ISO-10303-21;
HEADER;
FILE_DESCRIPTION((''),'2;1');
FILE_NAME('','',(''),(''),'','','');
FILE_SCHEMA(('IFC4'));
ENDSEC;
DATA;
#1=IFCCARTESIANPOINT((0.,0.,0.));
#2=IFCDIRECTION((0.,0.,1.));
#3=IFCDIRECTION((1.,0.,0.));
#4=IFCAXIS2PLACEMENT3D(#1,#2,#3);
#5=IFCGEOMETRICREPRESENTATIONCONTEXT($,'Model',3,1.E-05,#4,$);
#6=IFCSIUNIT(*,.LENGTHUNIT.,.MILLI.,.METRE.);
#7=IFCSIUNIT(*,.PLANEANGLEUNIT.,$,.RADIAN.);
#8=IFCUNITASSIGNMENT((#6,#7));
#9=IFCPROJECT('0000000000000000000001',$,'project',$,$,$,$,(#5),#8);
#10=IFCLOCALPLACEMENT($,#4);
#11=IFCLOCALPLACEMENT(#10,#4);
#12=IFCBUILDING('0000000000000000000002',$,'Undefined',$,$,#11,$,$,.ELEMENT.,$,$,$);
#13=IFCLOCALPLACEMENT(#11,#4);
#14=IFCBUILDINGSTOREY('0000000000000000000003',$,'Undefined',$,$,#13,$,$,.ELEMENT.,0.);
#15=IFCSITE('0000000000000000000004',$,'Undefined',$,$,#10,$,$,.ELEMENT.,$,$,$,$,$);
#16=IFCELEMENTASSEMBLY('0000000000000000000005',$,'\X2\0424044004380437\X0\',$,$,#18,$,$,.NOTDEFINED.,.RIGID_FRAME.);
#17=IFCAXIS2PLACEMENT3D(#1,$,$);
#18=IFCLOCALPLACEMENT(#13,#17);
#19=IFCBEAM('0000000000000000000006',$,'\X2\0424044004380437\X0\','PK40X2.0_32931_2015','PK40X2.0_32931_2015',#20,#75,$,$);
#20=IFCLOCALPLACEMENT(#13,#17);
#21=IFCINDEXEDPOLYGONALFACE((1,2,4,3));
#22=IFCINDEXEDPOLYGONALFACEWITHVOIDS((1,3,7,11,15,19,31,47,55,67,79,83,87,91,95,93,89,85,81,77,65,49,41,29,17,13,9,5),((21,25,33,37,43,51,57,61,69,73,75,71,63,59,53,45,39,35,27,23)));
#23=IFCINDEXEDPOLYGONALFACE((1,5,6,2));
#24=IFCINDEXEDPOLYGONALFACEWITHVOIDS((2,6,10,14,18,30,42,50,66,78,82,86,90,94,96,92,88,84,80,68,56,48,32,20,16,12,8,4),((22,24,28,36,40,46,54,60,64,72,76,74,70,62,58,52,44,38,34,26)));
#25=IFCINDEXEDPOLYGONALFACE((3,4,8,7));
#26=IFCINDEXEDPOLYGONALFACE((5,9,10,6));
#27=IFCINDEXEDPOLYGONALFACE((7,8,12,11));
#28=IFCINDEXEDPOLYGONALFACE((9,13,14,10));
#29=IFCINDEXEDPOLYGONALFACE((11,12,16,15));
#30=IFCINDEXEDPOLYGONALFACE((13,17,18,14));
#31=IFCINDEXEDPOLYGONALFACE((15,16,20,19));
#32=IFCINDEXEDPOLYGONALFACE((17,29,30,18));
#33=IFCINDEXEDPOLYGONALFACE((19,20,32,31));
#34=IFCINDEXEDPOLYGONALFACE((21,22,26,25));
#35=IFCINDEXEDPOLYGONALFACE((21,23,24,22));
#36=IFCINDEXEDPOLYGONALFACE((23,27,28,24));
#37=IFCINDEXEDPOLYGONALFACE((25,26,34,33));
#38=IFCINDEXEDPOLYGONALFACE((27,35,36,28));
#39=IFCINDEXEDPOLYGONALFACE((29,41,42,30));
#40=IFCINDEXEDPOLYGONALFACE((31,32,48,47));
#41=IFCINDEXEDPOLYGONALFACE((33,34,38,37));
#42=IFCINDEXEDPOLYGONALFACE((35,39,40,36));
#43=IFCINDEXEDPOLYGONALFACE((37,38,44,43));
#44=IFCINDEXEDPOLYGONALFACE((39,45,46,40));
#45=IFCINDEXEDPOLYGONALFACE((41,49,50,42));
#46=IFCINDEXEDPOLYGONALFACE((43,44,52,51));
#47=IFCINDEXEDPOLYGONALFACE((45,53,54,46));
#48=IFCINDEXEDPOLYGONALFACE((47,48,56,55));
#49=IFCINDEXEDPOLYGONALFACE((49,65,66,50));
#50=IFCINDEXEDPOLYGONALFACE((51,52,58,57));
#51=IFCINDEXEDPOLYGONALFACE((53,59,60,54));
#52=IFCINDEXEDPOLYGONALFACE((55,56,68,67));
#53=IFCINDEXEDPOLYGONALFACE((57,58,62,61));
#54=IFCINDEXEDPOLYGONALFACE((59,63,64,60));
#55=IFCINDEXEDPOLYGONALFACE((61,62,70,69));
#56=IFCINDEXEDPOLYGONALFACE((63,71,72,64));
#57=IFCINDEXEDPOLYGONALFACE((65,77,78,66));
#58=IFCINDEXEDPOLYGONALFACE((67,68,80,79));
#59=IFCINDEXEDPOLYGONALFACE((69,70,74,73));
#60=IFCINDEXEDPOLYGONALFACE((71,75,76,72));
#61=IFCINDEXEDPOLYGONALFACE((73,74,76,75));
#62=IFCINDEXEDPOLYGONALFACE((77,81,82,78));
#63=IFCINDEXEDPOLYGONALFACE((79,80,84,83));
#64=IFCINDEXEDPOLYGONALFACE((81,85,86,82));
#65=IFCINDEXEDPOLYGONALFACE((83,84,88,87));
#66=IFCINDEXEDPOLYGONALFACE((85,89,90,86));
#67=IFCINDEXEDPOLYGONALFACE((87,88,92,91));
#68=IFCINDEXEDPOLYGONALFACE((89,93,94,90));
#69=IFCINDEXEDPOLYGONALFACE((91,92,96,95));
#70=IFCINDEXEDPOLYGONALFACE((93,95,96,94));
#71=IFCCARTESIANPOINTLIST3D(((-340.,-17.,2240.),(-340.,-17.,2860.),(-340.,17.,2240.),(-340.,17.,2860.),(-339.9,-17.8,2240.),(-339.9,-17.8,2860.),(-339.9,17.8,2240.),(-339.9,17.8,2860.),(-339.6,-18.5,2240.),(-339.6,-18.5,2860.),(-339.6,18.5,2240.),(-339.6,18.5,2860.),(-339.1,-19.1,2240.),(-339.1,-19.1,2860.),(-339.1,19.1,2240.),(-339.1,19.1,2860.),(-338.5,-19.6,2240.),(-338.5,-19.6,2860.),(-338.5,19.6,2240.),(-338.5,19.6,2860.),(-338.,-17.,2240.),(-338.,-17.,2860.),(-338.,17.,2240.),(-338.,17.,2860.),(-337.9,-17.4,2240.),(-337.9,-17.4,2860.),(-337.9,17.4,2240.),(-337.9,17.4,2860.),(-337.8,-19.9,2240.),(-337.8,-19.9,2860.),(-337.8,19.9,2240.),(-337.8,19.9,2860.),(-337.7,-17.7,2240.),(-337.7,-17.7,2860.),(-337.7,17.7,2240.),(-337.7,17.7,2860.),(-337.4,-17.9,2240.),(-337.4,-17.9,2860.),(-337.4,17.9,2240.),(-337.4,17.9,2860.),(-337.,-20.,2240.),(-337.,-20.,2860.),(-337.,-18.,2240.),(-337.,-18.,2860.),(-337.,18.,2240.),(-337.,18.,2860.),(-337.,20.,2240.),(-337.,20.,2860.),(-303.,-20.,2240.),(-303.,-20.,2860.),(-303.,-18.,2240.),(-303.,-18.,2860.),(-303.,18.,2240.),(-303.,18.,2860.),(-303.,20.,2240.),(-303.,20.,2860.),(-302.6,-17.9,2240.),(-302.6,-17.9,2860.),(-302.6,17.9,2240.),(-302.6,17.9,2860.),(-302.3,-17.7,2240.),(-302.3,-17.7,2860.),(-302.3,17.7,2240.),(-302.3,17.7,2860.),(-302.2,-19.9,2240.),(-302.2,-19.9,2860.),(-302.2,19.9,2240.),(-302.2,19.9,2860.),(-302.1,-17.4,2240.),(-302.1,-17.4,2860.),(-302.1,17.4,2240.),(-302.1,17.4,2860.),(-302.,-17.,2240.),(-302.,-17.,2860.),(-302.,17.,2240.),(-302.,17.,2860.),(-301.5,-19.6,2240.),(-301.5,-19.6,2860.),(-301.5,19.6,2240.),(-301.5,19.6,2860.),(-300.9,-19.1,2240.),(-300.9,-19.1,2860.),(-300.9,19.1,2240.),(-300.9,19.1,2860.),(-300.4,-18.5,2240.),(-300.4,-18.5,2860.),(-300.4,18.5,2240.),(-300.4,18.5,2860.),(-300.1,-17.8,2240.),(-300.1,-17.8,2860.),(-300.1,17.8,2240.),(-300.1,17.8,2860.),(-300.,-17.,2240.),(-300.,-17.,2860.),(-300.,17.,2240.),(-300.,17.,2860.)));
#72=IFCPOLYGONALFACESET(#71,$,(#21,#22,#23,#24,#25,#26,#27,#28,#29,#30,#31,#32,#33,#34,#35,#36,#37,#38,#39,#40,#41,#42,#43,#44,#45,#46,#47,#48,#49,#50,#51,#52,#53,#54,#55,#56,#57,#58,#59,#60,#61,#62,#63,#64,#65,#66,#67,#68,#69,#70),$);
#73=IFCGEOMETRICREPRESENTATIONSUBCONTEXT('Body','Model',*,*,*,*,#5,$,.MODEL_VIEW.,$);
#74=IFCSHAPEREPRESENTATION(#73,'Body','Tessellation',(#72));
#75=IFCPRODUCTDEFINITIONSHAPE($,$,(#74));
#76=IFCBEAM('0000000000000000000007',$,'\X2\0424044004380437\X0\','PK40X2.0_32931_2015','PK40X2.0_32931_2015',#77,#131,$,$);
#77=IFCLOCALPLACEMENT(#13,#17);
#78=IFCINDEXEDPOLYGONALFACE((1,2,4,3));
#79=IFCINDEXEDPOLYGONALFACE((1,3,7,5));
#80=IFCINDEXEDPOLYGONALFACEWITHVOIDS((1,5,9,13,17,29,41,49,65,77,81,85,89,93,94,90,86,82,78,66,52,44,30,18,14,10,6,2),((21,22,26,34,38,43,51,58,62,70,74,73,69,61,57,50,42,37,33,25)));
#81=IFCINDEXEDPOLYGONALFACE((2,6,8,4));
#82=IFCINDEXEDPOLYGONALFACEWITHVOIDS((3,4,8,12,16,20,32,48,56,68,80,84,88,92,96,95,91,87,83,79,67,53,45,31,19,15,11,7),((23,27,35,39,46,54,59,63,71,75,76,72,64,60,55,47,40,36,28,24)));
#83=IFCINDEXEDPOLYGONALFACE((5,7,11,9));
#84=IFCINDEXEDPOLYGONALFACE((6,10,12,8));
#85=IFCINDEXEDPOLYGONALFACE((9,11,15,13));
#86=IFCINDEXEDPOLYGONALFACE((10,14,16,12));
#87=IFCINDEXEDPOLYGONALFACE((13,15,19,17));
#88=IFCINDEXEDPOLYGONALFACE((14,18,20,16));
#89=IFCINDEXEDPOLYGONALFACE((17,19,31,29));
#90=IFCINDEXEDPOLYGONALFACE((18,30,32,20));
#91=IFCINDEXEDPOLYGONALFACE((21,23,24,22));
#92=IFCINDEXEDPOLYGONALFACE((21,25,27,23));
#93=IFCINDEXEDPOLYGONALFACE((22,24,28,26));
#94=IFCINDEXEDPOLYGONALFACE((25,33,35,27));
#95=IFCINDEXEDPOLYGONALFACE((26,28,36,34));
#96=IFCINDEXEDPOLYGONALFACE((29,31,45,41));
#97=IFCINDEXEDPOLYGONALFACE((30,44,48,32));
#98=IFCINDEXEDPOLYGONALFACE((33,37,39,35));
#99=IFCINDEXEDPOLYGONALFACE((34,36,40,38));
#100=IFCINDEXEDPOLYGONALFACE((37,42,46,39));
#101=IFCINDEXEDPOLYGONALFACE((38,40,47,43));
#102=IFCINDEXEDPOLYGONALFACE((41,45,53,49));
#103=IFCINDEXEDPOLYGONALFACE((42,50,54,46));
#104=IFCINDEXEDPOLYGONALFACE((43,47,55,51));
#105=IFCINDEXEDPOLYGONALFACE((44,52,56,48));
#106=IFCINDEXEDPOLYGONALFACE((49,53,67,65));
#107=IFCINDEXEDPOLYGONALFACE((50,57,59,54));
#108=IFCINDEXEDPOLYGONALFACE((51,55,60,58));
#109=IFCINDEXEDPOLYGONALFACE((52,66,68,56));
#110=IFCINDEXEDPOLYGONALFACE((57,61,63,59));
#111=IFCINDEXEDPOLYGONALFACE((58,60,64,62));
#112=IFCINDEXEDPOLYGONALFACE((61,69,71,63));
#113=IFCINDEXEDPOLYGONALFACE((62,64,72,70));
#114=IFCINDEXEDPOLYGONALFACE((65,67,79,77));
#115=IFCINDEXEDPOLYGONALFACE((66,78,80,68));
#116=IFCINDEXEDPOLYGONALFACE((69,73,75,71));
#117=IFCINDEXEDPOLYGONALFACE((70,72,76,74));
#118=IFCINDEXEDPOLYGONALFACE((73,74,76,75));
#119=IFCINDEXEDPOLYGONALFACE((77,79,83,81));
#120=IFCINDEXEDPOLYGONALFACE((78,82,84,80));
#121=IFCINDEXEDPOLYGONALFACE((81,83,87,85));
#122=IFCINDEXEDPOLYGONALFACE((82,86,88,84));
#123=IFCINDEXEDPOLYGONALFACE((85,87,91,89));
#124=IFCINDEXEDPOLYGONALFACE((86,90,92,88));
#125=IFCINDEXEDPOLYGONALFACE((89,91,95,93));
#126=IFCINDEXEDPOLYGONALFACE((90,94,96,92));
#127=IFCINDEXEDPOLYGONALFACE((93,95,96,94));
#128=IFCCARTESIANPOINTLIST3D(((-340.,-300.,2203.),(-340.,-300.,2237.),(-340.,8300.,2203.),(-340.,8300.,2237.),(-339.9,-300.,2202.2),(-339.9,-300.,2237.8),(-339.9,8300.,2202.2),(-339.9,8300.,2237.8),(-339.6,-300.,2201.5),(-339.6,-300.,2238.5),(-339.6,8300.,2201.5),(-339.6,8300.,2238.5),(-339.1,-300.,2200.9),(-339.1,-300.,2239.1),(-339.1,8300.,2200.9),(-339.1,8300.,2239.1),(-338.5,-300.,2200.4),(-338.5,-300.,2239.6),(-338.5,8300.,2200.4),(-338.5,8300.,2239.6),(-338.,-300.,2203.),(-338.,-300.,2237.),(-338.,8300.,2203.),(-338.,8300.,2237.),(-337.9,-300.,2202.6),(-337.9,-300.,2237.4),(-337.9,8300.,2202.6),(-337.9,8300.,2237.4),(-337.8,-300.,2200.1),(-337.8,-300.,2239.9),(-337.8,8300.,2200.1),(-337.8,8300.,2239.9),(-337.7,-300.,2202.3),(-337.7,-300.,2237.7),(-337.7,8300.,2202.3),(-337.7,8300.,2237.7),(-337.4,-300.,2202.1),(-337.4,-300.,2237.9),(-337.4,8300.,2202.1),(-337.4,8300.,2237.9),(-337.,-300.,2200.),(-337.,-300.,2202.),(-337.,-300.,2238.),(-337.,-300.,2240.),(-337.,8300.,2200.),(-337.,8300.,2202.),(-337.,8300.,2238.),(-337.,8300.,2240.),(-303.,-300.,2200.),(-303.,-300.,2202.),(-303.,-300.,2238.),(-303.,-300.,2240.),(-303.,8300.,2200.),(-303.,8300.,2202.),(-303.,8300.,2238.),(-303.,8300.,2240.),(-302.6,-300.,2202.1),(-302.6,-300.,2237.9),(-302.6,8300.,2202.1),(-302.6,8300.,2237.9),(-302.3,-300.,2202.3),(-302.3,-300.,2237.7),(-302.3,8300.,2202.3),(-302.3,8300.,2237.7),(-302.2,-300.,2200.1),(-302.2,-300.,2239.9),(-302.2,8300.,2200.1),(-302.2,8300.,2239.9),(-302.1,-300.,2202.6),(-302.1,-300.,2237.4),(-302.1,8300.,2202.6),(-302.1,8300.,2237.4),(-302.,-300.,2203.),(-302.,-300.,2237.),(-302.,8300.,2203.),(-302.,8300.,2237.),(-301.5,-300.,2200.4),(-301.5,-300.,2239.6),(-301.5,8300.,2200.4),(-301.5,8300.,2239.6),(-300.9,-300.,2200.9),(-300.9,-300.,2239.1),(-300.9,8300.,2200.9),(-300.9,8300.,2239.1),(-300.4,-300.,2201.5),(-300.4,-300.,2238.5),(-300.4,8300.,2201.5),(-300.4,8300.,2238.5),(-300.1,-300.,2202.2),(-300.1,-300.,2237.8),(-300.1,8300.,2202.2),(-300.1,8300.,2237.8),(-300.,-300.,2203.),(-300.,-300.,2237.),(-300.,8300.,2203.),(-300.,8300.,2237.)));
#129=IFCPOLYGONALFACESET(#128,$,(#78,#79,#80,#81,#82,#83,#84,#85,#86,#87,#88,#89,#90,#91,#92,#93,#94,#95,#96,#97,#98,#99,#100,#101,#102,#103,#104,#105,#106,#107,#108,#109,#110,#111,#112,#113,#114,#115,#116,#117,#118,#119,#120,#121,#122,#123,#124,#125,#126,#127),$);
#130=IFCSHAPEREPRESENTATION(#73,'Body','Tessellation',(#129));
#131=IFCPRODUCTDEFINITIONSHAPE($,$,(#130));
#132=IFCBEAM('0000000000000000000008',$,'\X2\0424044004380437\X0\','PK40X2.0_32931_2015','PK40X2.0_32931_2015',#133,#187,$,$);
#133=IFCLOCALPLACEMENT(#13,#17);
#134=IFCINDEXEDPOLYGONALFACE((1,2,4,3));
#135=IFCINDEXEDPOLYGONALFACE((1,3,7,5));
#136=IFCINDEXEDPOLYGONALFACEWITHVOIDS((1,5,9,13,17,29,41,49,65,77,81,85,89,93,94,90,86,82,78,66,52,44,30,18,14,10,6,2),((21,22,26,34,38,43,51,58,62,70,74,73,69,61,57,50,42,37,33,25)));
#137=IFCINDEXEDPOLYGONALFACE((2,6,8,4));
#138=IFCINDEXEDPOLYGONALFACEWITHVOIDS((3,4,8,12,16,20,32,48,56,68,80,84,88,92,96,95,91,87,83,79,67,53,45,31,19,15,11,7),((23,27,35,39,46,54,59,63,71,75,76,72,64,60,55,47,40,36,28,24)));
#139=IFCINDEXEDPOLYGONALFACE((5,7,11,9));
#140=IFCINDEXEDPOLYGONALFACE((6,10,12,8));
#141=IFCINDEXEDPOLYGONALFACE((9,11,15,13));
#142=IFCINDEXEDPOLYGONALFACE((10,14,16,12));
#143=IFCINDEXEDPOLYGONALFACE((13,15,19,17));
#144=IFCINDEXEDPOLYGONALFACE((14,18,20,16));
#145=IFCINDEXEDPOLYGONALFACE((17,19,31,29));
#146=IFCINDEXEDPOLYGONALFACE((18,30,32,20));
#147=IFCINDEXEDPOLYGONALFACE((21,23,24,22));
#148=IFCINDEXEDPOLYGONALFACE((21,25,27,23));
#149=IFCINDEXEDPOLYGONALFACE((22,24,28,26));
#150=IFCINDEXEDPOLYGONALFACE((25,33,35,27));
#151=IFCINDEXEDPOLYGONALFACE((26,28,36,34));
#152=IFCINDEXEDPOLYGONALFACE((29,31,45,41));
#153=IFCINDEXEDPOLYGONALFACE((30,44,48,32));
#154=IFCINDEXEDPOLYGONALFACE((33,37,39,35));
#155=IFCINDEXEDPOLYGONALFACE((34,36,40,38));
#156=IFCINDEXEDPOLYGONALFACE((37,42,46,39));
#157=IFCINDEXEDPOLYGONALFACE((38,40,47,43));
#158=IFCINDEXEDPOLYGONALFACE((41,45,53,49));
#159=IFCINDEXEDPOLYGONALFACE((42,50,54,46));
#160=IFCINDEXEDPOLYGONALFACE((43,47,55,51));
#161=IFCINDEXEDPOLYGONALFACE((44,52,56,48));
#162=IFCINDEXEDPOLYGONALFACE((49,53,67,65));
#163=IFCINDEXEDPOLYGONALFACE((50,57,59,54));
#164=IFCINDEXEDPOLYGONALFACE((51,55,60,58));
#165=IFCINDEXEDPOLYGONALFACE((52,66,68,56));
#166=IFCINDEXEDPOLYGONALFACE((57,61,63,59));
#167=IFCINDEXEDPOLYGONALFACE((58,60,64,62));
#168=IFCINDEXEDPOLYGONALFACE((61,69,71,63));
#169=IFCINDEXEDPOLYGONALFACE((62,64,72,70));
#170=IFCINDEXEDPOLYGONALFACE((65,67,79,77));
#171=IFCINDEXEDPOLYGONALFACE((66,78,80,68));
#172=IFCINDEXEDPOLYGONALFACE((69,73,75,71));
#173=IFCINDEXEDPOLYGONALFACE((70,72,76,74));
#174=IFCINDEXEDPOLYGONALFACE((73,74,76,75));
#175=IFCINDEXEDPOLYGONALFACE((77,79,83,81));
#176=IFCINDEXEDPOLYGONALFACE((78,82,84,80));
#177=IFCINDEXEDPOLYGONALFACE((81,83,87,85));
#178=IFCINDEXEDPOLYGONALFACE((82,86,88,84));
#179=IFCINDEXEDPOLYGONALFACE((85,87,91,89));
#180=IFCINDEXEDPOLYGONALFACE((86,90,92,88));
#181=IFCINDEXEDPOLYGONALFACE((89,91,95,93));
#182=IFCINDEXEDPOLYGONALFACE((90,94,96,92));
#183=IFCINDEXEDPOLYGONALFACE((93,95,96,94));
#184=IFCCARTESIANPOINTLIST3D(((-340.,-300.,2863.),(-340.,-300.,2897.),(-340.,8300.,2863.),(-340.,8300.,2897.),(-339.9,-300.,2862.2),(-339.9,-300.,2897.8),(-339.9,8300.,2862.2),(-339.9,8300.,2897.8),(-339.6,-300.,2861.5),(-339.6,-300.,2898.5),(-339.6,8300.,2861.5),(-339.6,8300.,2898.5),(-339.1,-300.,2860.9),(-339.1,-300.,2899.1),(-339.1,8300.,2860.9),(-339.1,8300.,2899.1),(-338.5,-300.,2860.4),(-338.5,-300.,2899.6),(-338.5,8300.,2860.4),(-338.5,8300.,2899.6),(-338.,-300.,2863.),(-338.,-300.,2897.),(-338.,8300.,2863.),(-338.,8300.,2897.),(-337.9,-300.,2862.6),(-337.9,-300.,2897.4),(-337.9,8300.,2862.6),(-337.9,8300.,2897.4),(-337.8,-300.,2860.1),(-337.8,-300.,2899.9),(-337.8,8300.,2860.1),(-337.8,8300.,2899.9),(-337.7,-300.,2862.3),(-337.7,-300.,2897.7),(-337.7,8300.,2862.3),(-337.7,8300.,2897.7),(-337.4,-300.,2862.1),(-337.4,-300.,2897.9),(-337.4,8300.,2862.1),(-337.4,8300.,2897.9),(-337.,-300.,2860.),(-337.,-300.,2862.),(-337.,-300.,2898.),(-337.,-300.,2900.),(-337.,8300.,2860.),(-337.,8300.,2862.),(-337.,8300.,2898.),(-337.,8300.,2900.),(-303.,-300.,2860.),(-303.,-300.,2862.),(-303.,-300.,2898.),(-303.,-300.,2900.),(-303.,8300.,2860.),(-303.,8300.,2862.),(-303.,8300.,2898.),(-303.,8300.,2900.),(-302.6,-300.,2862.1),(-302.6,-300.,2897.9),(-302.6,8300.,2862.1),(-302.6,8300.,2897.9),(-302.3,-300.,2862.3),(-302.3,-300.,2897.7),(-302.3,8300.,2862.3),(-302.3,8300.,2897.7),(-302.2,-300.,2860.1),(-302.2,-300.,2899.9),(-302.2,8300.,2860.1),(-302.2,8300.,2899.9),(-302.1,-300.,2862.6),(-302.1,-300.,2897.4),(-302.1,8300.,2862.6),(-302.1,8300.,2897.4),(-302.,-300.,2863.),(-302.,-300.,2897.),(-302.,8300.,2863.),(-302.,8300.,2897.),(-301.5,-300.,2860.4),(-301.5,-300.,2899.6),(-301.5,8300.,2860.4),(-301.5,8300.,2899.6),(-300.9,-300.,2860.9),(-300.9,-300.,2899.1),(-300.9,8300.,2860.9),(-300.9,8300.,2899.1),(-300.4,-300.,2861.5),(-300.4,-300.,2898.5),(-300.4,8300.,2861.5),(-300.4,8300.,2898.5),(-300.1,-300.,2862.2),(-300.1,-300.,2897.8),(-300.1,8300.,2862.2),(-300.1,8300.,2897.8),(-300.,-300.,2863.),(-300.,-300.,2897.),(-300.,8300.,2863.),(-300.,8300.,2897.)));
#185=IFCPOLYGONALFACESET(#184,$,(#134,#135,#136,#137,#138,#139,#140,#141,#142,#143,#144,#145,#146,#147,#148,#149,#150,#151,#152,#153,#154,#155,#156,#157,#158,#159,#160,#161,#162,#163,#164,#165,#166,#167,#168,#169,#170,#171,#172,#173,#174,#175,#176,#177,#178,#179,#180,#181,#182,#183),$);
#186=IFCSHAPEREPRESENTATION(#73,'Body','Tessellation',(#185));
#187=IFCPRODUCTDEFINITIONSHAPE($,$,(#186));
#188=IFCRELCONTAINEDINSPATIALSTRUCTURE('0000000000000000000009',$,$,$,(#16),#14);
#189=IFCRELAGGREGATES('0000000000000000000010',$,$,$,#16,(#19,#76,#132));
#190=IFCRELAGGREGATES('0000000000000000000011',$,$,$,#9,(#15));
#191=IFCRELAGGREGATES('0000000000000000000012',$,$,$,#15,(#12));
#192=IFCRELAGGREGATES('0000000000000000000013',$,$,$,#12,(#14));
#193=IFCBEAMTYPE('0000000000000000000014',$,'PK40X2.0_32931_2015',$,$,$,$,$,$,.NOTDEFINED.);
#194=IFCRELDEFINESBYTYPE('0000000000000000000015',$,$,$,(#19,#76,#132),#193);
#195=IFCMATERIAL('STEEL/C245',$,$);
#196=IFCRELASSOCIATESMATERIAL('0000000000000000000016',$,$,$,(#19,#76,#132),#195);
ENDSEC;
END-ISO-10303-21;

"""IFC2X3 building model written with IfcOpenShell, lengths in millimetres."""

from ifc_helpers import new_model, si_unit, frame, origin_with_axes, origin_2d_with_axis, place, context, subcontext, project, spatial, hollow_rectangle, extrude, material, type_object, element, aggregate, save


model = new_model("IFC2X3")

# Units and contexts
model_context = context("Model", 3, precision=1e-05, world=origin_with_axes())
body_context = subcontext(model_context, "Body", "Model", "MODEL_VIEW")
ifc_project = project(units=[si_unit("LENGTHUNIT", "METRE", prefix="MILLI"), si_unit("PLANEANGLEUNIT", "RADIAN")], contexts=[model_context])

# Site, building, storey
site_placement = place(None, origin_with_axes())
site = spatial("IfcSite", under=ifc_project, at=site_placement, Name="Undefined", CompositionType="ELEMENT")
building_placement = place(site_placement, origin_with_axes())
building = spatial("IfcBuilding", under=site, at=building_placement, Name="Undefined", CompositionType="ELEMENT")
storey_placement = place(building_placement, origin_with_axes())
storey = spatial("IfcBuildingStorey", under=building, at=storey_placement, Name="Undefined", CompositionType="ELEMENT", Elevation=0.0)

# Shared definitions
ifc_material_1 = material(Name="STEEL/C245")

# Shared definitions
beam_type_1 = type_object("IfcBeamType", Name="PK40X2.0_32931_2015", PredefinedType="NOTDEFINED")

# Element assembly, beams
assembly_1_placement = place(storey_placement, origin_with_axes())
assembly_1 = element("IfcElementAssembly", 1, at=assembly_1_placement, inside=storey, Name="Фриз", AssemblyPlace="NOTDEFINED", PredefinedType="RIGID_FRAME")
beam_1_placement = place(assembly_1_placement, frame((-320.0, 0.0, 2860.0), z_axis=(1.0, 0.0, 0.0), x_axis=(0.0, 0.0, -1.0)))
beam_1 = element("IfcBeam", 2, at=beam_1_placement, type_object=beam_type_1, material=ifc_material_1, Name="Фриз", Description="PK40X2.0_32931_2015", ObjectType="PK40X2.0_32931_2015", context=body_context, shape_type="SweptSolid", body=[
    extrude(hollow_rectangle(XDim=40.0, YDim=40.0, WallThickness=2.0, InnerFilletRadius=1.0, OuterFilletRadius=3.0, at=origin_2d_with_axis()), frame((620.0, 0.0, 0.0), z_axis=(-1.0, 0.0, 0.0), x_axis=(0.0, -1.0, 0.0)), (0.0, 0.0, 1.0), 620.0),
])
beam_2_placement = place(assembly_1_placement, frame((-320.0, -300.0, 2220.0), z_axis=(0.0, 0.0, 1.0), x_axis=(0.0, 1.0, 0.0)))
beam_2 = element("IfcBeam", 3, at=beam_2_placement, type_object=beam_type_1, material=ifc_material_1, Name="Фриз", Description="PK40X2.0_32931_2015", ObjectType="PK40X2.0_32931_2015", context=body_context, shape_type="SweptSolid", body=[
    extrude(hollow_rectangle(XDim=40.0, YDim=40.0, WallThickness=2.0, InnerFilletRadius=1.0, OuterFilletRadius=3.0, at=origin_2d_with_axis()), frame((8600.0, 0.0, 0.0), z_axis=(-1.0, 0.0, 0.0), x_axis=(0.0, -1.0, 0.0)), (0.0, 0.0, 1.0), 8600.0),
])
beam_3_placement = place(assembly_1_placement, frame((-320.0, -300.0, 2880.0), z_axis=(0.0, 0.0, 1.0), x_axis=(0.0, 1.0, 0.0)))
beam_3 = element("IfcBeam", 4, at=beam_3_placement, type_object=beam_type_1, material=ifc_material_1, Name="Фриз", Description="PK40X2.0_32931_2015", ObjectType="PK40X2.0_32931_2015", context=body_context, shape_type="SweptSolid", body=[
    extrude(hollow_rectangle(XDim=40.0, YDim=40.0, WallThickness=2.0, InnerFilletRadius=1.0, OuterFilletRadius=3.0, at=origin_2d_with_axis()), frame((8600.0, 0.0, 0.0), z_axis=(-1.0, 0.0, 0.0), x_axis=(0.0, -1.0, 0.0)), (0.0, 0.0, 1.0), 8600.0),
])
aggregate(assembly_1, [beam_1, beam_2, beam_3])

save(model, "model.ifc")
